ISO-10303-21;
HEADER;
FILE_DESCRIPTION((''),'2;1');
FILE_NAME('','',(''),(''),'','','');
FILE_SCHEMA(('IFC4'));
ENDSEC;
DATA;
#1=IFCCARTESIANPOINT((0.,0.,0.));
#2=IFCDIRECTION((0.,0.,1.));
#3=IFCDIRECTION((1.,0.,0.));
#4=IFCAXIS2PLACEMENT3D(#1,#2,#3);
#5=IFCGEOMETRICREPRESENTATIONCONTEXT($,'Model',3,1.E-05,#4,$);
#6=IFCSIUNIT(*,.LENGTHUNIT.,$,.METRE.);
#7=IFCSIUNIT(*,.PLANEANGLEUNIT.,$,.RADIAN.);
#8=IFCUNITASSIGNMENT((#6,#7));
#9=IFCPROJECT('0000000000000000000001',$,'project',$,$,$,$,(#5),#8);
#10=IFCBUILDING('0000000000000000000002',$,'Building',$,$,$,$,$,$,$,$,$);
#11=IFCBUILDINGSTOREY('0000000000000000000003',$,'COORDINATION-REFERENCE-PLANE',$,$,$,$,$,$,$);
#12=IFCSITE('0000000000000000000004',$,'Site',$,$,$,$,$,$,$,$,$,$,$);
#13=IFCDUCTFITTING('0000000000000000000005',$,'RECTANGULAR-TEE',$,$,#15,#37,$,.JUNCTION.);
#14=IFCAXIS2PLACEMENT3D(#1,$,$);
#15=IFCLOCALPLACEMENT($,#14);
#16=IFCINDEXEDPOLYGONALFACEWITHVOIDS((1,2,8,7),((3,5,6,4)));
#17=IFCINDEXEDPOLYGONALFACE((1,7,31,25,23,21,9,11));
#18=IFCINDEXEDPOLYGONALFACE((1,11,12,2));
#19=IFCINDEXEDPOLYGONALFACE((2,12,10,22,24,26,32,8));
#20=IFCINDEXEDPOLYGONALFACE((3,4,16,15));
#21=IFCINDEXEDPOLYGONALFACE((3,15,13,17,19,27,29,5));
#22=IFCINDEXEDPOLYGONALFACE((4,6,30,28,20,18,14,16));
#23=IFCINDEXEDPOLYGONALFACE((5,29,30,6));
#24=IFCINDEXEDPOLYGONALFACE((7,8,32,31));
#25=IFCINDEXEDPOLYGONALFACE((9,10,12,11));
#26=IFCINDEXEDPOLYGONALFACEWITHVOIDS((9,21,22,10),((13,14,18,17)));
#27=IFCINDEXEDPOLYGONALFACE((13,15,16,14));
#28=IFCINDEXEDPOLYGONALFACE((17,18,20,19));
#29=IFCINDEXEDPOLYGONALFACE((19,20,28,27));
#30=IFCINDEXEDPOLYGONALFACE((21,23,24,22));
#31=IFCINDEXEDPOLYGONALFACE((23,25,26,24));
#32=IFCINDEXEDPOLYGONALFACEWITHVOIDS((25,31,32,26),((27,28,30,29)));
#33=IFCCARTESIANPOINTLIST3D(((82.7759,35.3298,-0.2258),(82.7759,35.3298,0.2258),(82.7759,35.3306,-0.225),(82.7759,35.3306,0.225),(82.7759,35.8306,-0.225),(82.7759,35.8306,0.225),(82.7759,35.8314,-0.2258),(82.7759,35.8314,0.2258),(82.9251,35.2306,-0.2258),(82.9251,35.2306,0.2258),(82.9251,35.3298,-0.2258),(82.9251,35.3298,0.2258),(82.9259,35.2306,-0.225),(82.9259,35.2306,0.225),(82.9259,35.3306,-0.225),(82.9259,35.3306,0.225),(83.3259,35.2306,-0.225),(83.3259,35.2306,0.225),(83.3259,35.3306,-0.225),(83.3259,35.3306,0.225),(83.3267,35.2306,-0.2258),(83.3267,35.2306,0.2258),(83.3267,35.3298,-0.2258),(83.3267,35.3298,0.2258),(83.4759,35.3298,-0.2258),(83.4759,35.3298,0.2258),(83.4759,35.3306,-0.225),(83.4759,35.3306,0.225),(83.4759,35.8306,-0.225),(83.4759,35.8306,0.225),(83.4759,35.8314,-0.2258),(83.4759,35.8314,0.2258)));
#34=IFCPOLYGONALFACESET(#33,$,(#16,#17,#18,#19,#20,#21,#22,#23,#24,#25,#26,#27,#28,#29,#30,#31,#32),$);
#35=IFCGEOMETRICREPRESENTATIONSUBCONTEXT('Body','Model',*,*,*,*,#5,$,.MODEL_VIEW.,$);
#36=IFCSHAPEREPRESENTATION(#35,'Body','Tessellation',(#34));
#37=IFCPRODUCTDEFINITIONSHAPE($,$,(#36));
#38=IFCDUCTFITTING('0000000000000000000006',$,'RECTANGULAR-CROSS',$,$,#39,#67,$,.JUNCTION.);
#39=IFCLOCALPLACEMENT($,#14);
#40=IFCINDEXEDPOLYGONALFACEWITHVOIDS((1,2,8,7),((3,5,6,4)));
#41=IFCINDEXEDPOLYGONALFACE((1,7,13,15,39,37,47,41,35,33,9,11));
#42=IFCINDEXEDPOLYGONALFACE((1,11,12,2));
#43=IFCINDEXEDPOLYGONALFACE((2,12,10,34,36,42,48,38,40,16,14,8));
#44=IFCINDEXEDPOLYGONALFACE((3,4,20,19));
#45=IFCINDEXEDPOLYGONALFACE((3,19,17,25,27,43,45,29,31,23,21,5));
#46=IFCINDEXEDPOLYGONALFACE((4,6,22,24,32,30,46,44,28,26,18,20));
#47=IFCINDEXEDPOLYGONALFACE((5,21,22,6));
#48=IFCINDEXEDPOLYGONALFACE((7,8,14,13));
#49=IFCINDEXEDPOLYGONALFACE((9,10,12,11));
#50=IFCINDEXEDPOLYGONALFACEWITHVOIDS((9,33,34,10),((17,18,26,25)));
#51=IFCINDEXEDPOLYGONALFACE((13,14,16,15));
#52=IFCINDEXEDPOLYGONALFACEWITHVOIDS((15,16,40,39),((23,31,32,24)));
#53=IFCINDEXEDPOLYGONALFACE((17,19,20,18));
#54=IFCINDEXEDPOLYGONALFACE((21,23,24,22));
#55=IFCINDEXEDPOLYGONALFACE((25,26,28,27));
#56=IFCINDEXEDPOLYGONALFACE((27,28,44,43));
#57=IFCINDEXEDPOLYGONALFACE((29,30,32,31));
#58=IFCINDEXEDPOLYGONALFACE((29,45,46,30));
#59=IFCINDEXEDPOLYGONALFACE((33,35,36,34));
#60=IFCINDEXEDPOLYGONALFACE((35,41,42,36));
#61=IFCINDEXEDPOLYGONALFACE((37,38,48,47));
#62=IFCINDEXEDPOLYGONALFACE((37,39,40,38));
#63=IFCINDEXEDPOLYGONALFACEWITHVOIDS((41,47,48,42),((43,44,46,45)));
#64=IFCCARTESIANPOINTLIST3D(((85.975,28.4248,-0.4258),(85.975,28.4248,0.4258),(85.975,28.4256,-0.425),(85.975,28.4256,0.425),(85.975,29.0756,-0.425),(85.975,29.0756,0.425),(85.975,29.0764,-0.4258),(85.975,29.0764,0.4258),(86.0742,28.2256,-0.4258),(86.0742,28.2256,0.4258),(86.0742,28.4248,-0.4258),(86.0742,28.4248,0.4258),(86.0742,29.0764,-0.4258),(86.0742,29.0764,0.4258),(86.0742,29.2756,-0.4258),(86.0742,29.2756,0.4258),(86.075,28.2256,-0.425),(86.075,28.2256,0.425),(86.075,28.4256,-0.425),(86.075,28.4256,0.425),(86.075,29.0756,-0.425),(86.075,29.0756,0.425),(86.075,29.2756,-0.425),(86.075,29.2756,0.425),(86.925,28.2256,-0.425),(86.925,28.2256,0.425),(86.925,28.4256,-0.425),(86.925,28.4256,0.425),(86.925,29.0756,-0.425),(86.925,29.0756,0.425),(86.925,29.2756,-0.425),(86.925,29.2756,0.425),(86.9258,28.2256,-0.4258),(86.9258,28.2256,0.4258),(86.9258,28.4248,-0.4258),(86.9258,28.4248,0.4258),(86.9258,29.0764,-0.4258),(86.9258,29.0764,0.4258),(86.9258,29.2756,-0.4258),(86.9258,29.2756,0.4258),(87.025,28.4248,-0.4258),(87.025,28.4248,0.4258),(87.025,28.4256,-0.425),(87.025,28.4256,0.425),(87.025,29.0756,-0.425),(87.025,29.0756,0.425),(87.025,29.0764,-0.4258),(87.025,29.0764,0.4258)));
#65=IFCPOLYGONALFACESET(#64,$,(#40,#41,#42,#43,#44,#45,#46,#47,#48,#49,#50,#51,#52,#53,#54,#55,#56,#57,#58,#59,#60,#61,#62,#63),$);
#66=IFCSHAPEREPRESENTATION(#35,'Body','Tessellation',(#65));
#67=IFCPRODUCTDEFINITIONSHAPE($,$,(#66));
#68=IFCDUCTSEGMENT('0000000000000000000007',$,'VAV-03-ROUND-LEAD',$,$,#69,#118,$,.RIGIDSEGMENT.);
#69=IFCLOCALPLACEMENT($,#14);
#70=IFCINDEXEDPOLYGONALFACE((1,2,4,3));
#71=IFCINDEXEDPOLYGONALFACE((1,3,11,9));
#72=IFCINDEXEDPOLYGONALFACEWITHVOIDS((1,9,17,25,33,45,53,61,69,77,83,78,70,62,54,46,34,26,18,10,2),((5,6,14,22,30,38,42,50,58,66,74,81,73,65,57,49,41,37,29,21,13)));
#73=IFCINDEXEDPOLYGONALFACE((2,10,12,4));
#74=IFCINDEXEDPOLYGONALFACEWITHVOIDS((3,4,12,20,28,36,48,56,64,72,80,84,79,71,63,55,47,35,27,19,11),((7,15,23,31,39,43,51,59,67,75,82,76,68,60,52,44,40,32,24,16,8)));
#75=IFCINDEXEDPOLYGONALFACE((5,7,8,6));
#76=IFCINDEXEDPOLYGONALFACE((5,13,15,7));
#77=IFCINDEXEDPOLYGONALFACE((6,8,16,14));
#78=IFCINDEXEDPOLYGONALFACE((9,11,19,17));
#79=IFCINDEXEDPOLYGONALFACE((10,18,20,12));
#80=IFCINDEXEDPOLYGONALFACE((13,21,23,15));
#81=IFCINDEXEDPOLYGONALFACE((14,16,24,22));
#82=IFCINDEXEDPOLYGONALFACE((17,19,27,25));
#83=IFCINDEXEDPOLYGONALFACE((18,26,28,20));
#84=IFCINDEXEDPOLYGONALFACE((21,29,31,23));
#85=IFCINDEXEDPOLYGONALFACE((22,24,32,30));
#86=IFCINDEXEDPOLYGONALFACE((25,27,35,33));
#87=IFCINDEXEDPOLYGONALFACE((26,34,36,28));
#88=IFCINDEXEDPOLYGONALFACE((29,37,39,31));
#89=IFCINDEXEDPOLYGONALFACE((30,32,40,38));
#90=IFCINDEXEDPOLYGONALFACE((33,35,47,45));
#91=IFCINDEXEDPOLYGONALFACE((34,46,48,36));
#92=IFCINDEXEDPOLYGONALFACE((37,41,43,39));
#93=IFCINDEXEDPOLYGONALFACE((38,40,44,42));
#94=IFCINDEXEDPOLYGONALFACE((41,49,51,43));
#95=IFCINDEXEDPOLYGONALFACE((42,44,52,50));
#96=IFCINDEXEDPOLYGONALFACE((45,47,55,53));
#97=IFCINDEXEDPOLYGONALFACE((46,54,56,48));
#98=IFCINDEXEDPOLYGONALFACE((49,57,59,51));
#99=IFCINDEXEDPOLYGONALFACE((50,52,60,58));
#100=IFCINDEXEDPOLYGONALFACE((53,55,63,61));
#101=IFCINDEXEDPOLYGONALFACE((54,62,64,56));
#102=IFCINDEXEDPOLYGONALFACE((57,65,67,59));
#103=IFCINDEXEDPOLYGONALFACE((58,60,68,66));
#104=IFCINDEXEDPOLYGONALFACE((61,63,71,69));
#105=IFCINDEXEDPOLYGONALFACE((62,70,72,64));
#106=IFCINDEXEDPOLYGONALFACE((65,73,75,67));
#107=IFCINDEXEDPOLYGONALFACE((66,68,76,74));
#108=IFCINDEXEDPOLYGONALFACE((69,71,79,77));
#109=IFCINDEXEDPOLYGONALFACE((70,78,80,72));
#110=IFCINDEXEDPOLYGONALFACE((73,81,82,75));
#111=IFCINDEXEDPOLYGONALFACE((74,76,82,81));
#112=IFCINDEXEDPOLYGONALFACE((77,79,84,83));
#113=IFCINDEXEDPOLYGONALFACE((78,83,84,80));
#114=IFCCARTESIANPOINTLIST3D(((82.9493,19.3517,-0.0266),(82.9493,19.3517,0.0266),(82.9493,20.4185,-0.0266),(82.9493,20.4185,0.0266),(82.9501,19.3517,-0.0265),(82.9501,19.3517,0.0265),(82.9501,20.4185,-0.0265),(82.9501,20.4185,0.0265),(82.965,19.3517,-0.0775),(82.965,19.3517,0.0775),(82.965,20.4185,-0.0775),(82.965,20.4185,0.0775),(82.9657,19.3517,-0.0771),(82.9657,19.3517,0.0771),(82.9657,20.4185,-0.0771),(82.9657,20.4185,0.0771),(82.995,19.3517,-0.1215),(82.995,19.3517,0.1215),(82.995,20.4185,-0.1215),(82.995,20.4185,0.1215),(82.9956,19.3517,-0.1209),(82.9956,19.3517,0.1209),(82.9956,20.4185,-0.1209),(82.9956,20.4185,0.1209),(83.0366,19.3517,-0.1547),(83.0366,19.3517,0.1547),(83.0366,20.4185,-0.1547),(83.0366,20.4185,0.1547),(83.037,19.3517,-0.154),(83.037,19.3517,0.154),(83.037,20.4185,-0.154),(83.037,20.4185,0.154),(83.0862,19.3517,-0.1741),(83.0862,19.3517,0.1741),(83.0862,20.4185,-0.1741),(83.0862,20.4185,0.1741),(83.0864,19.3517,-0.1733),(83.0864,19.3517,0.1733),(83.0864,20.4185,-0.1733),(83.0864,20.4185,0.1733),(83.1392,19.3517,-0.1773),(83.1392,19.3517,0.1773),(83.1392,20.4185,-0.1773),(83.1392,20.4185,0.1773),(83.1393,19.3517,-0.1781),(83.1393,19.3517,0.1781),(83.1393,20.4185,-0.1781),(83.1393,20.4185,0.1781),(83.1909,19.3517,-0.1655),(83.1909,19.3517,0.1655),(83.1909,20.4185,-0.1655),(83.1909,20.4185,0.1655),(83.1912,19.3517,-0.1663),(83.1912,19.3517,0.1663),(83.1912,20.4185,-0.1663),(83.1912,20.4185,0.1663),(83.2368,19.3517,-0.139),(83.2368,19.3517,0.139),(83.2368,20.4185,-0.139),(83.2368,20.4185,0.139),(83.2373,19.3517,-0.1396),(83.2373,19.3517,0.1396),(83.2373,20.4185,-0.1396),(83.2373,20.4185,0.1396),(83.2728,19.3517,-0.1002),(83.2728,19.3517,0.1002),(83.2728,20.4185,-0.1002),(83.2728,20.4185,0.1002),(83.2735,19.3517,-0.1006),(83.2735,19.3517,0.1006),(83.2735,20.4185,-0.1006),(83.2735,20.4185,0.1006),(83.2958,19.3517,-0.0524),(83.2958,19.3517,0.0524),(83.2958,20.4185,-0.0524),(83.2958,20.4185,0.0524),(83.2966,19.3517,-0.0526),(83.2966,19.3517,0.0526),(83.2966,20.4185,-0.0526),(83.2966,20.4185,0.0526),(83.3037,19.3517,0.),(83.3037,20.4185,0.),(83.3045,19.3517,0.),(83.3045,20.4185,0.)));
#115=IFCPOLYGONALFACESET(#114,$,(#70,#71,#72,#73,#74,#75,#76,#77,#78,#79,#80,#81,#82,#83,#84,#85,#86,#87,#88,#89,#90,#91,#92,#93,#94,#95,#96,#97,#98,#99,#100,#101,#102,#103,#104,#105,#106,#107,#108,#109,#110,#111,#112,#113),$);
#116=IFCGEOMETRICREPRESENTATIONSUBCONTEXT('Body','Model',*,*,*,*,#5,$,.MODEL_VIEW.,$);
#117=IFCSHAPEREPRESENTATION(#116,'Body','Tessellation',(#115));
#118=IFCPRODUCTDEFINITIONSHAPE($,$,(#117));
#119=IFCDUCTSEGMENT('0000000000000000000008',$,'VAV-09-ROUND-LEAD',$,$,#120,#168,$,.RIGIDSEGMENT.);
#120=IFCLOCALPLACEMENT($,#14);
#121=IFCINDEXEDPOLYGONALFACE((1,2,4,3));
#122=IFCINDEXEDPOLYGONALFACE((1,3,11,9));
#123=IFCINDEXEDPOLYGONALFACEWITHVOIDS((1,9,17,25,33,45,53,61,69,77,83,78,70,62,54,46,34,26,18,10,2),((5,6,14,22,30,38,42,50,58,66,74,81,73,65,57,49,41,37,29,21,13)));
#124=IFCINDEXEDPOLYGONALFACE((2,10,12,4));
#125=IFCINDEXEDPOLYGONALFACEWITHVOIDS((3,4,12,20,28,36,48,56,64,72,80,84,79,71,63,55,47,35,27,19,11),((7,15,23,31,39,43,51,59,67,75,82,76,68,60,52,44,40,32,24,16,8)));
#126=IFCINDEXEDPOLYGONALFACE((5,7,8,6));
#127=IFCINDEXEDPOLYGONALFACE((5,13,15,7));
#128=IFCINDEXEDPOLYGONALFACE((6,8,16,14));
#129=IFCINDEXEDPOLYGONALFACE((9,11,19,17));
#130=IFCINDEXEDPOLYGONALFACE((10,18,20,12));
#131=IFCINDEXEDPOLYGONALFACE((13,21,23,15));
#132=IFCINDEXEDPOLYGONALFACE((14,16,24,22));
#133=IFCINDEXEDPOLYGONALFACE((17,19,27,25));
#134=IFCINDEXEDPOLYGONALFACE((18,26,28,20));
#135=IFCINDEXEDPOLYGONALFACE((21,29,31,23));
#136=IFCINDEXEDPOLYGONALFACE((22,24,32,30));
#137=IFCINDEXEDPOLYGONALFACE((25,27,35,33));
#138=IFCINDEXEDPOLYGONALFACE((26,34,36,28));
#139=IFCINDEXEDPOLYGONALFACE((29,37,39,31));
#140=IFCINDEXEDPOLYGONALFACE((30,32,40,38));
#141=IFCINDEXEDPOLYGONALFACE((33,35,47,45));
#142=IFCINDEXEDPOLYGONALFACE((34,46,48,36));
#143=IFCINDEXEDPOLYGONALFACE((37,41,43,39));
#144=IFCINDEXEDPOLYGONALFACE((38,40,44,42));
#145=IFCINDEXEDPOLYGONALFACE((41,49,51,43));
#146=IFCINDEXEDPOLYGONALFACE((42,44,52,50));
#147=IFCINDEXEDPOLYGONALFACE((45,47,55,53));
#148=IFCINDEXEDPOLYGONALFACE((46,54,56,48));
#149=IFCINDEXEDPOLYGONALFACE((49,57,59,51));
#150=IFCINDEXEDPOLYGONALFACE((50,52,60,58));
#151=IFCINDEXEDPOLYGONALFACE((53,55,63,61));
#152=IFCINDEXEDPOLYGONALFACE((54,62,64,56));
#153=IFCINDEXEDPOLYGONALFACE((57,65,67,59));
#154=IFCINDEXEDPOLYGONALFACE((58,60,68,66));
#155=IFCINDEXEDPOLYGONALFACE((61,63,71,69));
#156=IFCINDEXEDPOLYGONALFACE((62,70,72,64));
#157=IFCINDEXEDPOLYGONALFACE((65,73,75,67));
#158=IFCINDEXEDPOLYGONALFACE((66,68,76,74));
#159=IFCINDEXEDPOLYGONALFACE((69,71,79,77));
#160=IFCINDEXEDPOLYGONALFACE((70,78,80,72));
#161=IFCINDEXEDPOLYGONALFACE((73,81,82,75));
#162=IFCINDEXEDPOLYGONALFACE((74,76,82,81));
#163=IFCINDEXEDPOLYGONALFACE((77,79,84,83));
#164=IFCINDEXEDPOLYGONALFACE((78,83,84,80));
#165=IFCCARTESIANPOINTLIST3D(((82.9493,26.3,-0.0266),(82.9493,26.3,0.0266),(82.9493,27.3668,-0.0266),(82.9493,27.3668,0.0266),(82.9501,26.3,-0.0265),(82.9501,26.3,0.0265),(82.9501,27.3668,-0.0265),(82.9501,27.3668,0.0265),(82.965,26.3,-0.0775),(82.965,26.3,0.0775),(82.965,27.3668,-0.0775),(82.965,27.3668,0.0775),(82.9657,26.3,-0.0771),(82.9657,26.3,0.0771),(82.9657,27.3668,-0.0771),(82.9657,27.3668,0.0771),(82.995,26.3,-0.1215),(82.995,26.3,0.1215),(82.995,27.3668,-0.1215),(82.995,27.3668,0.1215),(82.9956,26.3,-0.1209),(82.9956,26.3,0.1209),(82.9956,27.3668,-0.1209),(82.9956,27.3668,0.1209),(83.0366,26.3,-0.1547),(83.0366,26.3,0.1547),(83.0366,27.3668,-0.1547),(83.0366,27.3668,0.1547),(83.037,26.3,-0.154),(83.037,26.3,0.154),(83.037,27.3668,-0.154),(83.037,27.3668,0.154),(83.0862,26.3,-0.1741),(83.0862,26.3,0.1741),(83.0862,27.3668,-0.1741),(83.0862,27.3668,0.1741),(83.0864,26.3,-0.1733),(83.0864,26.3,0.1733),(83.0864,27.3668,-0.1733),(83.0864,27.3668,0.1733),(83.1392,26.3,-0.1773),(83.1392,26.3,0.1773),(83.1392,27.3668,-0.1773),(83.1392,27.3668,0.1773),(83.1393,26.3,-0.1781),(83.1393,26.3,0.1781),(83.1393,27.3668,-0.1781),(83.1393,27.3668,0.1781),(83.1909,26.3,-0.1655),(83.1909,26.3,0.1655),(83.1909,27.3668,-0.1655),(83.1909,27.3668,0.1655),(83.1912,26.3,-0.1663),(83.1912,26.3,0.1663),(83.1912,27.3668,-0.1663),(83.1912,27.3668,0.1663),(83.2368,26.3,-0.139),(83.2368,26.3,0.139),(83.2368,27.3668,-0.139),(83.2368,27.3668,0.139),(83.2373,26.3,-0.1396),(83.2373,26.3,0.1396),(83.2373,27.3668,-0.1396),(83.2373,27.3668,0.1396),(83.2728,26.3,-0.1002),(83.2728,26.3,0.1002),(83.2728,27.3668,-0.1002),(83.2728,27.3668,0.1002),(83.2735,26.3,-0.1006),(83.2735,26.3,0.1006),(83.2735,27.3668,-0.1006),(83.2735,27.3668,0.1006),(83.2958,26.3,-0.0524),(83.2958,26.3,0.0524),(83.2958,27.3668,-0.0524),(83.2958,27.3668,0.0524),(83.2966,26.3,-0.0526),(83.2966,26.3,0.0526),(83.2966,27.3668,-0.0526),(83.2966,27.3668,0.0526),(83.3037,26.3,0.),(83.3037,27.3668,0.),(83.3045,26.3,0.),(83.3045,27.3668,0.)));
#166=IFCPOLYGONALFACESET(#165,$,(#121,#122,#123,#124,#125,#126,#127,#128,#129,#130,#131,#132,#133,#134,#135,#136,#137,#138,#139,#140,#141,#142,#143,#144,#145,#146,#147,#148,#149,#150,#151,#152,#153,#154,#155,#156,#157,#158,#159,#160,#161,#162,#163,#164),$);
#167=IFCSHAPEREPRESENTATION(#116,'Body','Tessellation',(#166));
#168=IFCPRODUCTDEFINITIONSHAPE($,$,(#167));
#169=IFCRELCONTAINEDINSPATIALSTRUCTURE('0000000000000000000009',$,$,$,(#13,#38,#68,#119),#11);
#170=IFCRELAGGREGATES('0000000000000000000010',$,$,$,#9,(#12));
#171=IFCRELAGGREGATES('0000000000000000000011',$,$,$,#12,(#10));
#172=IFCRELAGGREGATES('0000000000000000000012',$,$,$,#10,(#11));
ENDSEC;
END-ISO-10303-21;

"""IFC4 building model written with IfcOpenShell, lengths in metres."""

from ifc_helpers import new_model, si_unit, frame, origin, origin_with_axes, place, context, subcontext, project, spatial, rectangle, hollow_circle, extrude, boolean, element, save


model = new_model("IFC4")

# Units and contexts
model_context = context("Model", 3, precision=1e-05, world=origin_with_axes())
body_context_1 = subcontext(model_context, "Body", "Model", "MODEL_VIEW")
body_context_2 = subcontext(model_context, "Body", "Model", "MODEL_VIEW")
ifc_project = project(units=[si_unit("LENGTHUNIT", "METRE"), si_unit("PLANEANGLEUNIT", "RADIAN")], contexts=[model_context])

# Site, building, storey
site = spatial("IfcSite", under=ifc_project, Name="Site")
building = spatial("IfcBuilding", under=site, Name="Building")
storey = spatial("IfcBuildingStorey", under=building, Name="COORDINATION-REFERENCE-PLANE")

# Duct fittings
duct_fitting_1_placement = place(None, frame((83.1259, 35.5806, 0.0), z_axis=(-1.0, 0.0, 0.0), x_axis=(0.0, -1.0, 0.0)))
solid_1 = boolean("UNION", extrude(rectangle(XDim=0.5, YDim=0.45), frame((0.0, 0.0, -0.35), z_axis=(0.0, 0.0, 1.0), x_axis=(1.0, 0.0, 0.0)), (0.0, 0.0, 1.0), 0.7), extrude(rectangle(XDim=0.4, YDim=0.45), frame((0.0, 0.0, 0.0), z_axis=(1.0, 0.0, 0.0), x_axis=(0.0, 0.0, -1.0)), (0.0, 0.0, 1.0), 0.35))
element("IfcDuctFitting", 1, at=duct_fitting_1_placement, inside=storey, Name="RECTANGULAR-TEE", PredefinedType="JUNCTION", context=body_context_1, shape_type="CSG", body=[
    boolean("DIFFERENCE", boolean("UNION", extrude(rectangle(XDim=0.5016, YDim=0.4516), frame((0.0, 0.0, -0.35), z_axis=(0.0, 0.0, 1.0), x_axis=(1.0, 0.0, 0.0)), (0.0, 0.0, 1.0), 0.7), extrude(rectangle(XDim=0.4016, YDim=0.4516), frame((0.0, 0.0, 0.0), z_axis=(1.0, 0.0, 0.0), x_axis=(0.0, 0.0, -1.0)), (0.0, 0.0, 1.0), 0.35)), solid_1),
])
duct_fitting_2_placement = place(None, frame((86.5, 28.7506, 0.0), z_axis=(0.0, -1.0, 0.0), x_axis=(1.0, 0.0, 0.0)))
solid_2 = boolean("UNION", extrude(rectangle(XDim=0.85, YDim=0.85), frame((0.0, 0.0, -0.525), z_axis=(0.0, 0.0, 1.0), x_axis=(1.0, 0.0, 0.0)), (0.0, 0.0, 1.0), 1.05), extrude(rectangle(XDim=0.65, YDim=0.85), frame((-0.525, 0.0, 0.0), z_axis=(1.0, 0.0, 0.0), x_axis=(0.0, 0.0, -1.0)), (0.0, 0.0, 1.0), 1.05))
element("IfcDuctFitting", 2, at=duct_fitting_2_placement, inside=storey, Name="RECTANGULAR-CROSS", PredefinedType="JUNCTION", context=body_context_1, shape_type="CSG", body=[
    boolean("DIFFERENCE", boolean("UNION", extrude(rectangle(XDim=0.8516, YDim=0.8516), frame((0.0, 0.0, -0.525), z_axis=(0.0, 0.0, 1.0), x_axis=(1.0, 0.0, 0.0)), (0.0, 0.0, 1.0), 1.05), extrude(rectangle(XDim=0.6516, YDim=0.8516), frame((-0.525, 0.0, 0.0), z_axis=(1.0, 0.0, 0.0), x_axis=(0.0, 0.0, -1.0)), (0.0, 0.0, 1.0), 1.05)), solid_2),
])

# Duct segments
for number, where, z_axis, x_axis, name in (
    (3, (83.1259, 20.4185, 0.0), (0.0, -1.0, 0.0), (1.0, 0.0, 0.0), "VAV-03-ROUND-LEAD"),
    (4, (83.1259, 27.3668, 0.0), (0.0, -1.0, 0.0), (1.0, 0.0, 0.0), "VAV-09-ROUND-LEAD"),
):
    element("IfcDuctSegment", number, at=place(None, frame(where, z_axis=z_axis, x_axis=x_axis)), inside=storey, Name=name, PredefinedType="RIGIDSEGMENT", context=body_context_2, shape_type="SweptSolid", body=[
        extrude(hollow_circle(Radius=0.1786, WallThickness=0.0008), origin(), (0.0, 0.0, 1.0), 1.0668),
    ])

save(model, "model.ifc")
